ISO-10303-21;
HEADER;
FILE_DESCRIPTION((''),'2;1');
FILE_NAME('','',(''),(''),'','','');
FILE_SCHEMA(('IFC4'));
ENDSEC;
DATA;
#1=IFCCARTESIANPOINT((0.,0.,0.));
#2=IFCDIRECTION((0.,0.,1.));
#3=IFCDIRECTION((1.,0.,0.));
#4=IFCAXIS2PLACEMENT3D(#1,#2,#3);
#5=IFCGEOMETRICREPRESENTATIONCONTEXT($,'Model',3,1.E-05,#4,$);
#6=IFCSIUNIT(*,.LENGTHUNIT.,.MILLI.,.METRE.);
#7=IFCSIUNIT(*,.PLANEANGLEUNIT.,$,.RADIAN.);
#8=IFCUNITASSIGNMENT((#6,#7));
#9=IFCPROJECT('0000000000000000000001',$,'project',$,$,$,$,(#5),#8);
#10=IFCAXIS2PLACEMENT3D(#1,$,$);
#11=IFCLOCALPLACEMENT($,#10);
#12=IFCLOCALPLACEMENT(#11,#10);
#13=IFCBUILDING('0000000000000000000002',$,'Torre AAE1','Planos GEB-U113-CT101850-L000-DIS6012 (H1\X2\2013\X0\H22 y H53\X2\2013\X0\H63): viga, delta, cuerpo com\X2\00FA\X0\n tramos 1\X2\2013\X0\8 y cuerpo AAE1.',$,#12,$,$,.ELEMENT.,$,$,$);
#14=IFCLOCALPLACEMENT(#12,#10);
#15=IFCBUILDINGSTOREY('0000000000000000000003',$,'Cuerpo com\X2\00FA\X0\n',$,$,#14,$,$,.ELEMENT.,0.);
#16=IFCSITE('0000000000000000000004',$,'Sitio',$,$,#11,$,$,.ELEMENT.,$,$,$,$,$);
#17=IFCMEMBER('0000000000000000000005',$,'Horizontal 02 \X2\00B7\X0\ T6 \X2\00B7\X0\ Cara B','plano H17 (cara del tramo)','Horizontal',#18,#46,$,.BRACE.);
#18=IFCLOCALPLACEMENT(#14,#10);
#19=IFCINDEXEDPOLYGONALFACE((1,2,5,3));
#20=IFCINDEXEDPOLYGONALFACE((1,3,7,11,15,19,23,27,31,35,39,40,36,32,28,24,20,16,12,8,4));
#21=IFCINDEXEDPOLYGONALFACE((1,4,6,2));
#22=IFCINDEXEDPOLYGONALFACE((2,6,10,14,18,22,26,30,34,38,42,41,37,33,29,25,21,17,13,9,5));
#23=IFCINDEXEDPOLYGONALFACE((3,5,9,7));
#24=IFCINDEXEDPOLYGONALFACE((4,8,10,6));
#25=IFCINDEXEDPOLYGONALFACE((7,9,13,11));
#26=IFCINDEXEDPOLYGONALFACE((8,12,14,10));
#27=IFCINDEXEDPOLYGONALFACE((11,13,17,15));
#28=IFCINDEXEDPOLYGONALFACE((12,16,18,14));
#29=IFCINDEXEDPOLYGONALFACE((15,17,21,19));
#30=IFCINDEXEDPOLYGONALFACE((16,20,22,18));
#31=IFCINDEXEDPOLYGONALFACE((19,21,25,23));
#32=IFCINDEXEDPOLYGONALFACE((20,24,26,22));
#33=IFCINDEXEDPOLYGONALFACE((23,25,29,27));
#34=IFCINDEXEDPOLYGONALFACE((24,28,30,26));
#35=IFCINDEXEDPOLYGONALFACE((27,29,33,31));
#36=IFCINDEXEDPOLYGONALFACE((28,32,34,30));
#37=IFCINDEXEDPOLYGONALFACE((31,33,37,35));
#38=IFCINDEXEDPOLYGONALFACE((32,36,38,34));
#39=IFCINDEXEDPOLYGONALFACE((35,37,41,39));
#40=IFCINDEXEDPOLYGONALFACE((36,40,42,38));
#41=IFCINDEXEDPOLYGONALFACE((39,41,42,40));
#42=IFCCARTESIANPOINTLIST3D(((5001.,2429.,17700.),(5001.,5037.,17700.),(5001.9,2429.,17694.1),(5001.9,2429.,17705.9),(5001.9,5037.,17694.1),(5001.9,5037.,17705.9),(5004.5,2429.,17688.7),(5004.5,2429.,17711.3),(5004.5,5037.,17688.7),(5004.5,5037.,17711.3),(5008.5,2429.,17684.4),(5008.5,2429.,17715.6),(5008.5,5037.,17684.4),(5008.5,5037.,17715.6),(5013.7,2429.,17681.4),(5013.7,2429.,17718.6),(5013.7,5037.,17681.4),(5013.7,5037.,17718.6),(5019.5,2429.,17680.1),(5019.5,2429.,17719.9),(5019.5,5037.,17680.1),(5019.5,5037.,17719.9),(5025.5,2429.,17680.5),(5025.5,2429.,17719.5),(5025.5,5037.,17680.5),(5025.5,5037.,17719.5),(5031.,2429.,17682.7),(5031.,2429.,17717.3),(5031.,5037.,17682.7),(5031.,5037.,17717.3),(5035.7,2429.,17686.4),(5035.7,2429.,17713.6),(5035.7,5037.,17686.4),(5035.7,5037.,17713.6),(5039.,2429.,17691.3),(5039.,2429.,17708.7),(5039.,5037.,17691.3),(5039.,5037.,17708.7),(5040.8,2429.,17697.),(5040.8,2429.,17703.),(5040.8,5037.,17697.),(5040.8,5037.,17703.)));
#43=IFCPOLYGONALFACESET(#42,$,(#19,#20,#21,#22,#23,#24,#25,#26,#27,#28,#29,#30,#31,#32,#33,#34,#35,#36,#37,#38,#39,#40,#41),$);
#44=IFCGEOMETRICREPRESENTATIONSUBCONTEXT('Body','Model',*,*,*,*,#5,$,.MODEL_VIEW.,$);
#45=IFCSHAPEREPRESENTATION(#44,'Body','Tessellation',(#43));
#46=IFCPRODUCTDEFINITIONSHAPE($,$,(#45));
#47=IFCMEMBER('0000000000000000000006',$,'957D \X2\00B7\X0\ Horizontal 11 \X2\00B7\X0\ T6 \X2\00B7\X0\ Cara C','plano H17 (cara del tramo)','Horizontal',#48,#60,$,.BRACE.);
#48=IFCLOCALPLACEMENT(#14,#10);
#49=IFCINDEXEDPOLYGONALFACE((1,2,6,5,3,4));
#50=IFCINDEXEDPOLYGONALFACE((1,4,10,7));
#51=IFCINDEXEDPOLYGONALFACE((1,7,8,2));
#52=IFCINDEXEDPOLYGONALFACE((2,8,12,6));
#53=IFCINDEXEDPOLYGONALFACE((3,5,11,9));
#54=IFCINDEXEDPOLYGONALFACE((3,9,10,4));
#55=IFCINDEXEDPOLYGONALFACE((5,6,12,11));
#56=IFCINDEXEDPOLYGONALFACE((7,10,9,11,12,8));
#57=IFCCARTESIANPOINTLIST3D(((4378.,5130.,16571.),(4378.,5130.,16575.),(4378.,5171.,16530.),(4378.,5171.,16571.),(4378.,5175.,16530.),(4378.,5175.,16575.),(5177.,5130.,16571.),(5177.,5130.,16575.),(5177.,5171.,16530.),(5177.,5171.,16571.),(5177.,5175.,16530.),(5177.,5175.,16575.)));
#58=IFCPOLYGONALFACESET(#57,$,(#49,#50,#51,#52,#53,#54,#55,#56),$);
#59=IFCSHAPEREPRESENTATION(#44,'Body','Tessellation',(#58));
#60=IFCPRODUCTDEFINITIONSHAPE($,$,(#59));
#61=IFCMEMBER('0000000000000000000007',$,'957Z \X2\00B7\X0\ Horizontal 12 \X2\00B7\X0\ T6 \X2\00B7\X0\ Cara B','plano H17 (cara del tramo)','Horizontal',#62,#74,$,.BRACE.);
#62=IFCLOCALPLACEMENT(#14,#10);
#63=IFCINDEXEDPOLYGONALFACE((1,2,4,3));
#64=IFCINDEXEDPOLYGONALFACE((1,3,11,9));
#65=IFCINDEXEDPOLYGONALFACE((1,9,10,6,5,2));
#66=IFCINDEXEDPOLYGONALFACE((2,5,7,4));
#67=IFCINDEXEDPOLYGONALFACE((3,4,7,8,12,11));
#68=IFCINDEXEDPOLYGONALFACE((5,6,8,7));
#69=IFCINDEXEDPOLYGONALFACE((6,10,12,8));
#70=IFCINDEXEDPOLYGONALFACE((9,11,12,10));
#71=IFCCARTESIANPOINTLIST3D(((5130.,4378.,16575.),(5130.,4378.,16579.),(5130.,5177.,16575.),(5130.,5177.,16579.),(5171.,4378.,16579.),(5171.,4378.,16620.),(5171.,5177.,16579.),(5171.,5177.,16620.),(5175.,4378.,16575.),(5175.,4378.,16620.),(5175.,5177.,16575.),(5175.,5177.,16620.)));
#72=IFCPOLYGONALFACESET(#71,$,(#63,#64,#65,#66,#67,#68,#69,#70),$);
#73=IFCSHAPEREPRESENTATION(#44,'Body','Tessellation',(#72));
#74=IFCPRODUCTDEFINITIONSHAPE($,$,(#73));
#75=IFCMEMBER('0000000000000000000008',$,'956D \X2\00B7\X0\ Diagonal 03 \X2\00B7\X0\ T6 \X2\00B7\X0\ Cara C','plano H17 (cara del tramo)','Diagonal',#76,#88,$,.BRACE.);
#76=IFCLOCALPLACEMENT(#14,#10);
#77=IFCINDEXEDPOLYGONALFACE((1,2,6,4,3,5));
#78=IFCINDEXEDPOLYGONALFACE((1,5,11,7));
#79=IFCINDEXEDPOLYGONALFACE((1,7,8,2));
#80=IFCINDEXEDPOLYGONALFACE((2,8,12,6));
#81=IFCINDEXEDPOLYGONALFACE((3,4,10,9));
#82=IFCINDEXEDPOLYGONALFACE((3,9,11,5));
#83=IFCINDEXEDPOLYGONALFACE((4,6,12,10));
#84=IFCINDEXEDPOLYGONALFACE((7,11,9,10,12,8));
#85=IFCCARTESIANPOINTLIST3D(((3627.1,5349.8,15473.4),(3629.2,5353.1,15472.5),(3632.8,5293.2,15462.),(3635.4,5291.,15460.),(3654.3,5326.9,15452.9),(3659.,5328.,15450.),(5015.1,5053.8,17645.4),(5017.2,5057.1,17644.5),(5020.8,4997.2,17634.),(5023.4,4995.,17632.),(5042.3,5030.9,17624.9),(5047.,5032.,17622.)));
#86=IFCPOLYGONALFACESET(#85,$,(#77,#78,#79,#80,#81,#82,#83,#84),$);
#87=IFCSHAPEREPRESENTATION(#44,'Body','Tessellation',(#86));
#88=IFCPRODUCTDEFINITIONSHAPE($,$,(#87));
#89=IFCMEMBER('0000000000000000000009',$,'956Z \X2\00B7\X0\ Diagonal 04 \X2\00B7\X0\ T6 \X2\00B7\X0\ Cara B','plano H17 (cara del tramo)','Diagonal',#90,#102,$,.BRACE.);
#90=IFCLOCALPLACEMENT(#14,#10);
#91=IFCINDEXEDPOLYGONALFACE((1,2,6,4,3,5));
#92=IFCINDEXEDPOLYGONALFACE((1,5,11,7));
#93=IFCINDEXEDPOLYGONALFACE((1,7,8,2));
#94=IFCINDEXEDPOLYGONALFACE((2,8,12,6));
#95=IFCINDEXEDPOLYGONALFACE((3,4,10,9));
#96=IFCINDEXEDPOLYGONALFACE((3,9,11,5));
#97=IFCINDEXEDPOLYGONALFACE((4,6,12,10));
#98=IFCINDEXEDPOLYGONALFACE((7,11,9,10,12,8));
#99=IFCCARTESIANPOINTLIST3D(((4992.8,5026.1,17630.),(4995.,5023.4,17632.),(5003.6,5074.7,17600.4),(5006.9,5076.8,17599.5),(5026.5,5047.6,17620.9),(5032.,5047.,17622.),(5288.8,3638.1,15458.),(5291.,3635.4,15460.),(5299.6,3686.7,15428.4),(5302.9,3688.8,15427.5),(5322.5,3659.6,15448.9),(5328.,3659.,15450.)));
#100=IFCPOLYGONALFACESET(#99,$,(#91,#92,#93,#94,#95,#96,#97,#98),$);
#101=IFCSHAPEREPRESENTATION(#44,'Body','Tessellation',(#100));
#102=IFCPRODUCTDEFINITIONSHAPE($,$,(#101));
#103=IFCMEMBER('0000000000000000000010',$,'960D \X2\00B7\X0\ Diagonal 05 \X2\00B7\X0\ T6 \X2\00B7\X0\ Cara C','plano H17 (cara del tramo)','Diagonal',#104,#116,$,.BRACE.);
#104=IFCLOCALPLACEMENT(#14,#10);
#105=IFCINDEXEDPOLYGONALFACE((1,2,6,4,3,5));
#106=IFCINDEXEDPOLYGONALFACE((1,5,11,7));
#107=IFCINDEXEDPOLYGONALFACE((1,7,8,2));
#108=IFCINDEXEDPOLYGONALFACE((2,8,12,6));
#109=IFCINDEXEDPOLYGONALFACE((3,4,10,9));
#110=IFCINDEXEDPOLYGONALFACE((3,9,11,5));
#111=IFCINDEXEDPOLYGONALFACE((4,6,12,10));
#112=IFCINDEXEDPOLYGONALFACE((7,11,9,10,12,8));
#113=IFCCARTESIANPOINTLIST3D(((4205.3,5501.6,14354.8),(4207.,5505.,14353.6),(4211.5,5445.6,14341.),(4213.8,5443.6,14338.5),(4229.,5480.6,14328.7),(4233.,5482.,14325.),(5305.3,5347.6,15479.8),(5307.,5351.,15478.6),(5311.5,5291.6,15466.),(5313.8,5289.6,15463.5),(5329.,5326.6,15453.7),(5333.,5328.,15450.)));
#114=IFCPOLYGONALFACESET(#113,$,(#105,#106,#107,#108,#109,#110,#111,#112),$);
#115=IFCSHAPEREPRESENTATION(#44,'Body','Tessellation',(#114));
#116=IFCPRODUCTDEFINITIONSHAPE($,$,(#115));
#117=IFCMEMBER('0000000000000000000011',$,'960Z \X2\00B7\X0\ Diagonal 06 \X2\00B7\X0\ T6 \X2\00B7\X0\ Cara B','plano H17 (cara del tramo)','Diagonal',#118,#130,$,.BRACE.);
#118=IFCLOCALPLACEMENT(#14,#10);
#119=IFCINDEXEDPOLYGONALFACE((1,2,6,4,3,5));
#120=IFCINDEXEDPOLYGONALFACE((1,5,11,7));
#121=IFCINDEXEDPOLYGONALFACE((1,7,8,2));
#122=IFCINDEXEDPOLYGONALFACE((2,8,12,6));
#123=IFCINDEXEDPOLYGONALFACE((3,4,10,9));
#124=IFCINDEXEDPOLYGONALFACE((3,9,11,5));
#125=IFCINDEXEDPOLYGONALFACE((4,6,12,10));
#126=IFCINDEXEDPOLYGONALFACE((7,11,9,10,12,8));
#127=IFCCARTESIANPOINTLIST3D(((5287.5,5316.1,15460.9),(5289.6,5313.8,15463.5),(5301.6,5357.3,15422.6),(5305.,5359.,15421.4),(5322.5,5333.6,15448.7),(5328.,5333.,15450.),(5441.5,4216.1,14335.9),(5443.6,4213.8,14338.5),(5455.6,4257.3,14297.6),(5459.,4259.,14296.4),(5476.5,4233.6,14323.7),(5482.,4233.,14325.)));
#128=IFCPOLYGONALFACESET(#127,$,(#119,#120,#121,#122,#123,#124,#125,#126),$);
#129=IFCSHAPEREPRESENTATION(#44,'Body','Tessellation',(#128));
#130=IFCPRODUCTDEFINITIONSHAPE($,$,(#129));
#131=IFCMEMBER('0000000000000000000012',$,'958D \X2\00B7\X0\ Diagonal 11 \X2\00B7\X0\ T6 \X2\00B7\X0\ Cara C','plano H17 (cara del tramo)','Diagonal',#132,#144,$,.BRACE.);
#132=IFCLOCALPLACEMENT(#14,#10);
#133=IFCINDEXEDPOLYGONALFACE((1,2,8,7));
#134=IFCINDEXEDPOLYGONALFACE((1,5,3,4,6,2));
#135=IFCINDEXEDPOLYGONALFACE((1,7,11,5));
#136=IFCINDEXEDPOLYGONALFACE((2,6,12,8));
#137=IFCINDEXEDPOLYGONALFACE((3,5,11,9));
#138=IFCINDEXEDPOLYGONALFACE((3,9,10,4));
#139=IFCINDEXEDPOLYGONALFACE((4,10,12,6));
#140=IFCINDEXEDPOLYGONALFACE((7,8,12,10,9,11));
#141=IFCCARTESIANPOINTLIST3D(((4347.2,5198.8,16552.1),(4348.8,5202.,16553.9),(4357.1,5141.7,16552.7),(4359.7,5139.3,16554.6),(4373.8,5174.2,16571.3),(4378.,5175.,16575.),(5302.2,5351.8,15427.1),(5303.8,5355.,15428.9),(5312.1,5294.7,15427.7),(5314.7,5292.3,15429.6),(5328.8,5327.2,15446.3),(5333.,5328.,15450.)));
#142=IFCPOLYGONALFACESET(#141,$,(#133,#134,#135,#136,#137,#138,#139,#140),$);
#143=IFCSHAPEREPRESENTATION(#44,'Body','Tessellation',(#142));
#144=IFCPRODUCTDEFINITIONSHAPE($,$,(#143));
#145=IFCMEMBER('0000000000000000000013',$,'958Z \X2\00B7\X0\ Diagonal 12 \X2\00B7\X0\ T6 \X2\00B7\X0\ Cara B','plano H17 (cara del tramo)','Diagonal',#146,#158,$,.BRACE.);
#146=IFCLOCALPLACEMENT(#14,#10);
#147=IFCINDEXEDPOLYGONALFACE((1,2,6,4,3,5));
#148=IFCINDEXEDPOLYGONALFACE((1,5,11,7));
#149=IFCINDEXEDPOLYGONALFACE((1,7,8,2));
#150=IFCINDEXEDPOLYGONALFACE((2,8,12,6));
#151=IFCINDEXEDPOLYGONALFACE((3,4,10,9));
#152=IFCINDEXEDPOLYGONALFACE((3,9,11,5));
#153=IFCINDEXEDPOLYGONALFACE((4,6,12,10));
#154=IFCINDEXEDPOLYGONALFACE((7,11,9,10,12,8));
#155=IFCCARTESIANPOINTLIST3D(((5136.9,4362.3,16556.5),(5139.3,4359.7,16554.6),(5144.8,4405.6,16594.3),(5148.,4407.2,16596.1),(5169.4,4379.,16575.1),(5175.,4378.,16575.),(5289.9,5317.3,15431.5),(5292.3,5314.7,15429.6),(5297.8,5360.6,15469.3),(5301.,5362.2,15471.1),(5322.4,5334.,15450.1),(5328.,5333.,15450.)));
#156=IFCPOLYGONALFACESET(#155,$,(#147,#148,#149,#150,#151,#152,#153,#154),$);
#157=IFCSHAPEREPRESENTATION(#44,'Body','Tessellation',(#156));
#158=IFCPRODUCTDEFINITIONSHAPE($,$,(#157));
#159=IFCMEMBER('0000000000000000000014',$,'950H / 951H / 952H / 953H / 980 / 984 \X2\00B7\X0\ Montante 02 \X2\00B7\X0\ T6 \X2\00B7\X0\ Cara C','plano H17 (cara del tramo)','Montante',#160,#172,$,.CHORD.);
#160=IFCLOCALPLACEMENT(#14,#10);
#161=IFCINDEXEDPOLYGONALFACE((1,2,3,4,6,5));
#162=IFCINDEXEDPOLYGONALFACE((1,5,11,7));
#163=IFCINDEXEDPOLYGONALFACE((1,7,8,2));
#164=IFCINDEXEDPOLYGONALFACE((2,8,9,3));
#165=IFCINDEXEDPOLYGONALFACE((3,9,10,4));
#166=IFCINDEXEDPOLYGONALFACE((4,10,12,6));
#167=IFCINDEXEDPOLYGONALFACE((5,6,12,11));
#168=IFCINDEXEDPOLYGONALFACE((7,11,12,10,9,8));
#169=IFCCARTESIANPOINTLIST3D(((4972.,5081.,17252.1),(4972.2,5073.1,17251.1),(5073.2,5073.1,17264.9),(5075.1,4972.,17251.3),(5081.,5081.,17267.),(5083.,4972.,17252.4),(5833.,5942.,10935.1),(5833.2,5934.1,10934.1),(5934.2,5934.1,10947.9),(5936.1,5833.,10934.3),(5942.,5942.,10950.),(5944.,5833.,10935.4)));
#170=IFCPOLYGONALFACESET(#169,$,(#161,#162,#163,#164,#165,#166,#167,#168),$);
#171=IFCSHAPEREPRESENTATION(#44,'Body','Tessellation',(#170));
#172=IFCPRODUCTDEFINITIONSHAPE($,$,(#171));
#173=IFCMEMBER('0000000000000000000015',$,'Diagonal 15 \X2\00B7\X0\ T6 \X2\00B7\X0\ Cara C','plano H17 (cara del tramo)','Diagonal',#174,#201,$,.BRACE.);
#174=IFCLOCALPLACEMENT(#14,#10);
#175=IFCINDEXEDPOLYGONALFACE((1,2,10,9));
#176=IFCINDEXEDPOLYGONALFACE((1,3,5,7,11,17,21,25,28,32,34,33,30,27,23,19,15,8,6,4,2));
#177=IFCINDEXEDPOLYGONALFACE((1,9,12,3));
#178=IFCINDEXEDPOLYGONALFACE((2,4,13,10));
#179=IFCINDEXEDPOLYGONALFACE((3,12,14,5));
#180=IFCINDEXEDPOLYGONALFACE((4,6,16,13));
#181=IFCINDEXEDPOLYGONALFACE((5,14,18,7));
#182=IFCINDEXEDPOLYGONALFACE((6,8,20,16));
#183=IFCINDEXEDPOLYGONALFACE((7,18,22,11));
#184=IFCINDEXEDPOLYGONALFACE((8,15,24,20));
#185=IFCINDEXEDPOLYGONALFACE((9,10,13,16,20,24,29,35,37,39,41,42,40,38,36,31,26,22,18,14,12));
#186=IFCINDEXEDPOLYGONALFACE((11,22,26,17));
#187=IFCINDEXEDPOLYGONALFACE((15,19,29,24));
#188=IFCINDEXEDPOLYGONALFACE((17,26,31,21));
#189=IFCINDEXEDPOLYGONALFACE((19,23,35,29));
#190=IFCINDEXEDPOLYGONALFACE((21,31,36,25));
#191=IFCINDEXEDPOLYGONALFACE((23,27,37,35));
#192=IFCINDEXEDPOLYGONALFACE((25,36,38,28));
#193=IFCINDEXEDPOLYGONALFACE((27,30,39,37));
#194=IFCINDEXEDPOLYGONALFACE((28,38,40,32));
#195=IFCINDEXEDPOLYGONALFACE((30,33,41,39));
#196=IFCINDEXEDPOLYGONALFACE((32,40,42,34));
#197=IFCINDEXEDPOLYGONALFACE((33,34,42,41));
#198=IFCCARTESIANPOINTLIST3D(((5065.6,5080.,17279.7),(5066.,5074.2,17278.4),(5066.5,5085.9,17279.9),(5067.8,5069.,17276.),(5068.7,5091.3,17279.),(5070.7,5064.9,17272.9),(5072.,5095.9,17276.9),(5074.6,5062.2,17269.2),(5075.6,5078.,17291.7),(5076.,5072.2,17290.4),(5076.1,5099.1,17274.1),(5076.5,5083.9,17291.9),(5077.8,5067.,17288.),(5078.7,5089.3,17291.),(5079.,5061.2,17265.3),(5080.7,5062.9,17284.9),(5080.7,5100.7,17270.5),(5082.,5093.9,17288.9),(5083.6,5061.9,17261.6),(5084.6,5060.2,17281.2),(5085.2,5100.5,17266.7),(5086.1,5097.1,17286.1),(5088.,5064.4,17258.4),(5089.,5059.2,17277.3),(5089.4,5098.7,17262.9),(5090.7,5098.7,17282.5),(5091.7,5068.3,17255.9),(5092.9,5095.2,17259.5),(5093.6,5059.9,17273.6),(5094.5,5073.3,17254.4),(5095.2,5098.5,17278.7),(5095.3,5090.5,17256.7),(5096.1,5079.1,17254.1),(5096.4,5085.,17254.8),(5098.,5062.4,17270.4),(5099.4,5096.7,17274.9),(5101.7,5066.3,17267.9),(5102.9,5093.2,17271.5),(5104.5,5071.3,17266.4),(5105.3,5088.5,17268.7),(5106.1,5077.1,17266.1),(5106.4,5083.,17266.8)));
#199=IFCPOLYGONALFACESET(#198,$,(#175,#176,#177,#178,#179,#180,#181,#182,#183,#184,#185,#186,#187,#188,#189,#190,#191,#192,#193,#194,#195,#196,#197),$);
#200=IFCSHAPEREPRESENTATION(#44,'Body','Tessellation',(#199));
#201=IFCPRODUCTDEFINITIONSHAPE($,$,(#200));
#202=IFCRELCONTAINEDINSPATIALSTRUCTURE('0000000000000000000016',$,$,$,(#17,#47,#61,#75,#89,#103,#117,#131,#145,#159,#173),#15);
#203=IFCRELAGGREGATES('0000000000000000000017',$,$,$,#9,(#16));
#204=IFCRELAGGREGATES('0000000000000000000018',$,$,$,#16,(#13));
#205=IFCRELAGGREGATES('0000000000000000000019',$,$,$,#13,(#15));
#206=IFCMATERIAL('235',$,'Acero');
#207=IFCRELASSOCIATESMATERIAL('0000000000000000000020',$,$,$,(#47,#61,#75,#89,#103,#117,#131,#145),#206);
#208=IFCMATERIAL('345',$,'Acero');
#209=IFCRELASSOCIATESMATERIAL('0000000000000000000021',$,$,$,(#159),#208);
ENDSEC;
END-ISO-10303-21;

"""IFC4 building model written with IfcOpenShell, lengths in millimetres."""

from ifc_helpers import new_model, si_unit, frame, frame_2d, origin, origin_with_axes, place, context, subcontext, project, spatial, circle, l_section, extrude, material, element, save


model = new_model("IFC4")

# Units and contexts
model_context = context("Model", 3, precision=1e-05, world=origin_with_axes())
body_context = subcontext(model_context, "Body", "Model", "MODEL_VIEW")
ifc_project = project(units=[si_unit("LENGTHUNIT", "METRE", prefix="MILLI"), si_unit("PLANEANGLEUNIT", "RADIAN")], contexts=[model_context])

# Site, building, storey
site_placement = place(None, origin())
site = spatial("IfcSite", under=ifc_project, at=site_placement, Name="Sitio", CompositionType="ELEMENT")
building_placement = place(site_placement, origin())
building = spatial("IfcBuilding", under=site, at=building_placement, Name="Torre AAE1", Description="Planos GEB-U113-CT101850-L000-DIS6012 (H1–H22 y H53–H63): viga, delta, cuerpo común tramos 1–8 y cuerpo AAE1.", CompositionType="ELEMENT")
storey_placement = place(building_placement, origin())
storey = spatial("IfcBuildingStorey", under=building, at=storey_placement, Name="Cuerpo común", CompositionType="ELEMENT", Elevation=0.0)

# Members
for number, where, z_axis, x_axis, name in (
    (1, (5021.0, 5037.0, 17700.0), (0.0, -1.0, 0.0), (-1.0, 0.0, 0.0), "Horizontal 02 · T6 · Cara B"),
):
    element("IfcMember", number, at=place(storey_placement, frame(where, z_axis=z_axis, x_axis=x_axis)), inside=storey, Name=name, Description="plano H17 (cara del tramo)", ObjectType="Horizontal", PredefinedType="BRACE", context=body_context, shape_type="SweptSolid", body=[
        extrude(circle(Radius=20.0), None, (0.0, 0.0, 1.0), 2608.0),
    ])
ifc_material_1 = material(Name="235", Category="Acero")
for number, where, z_axis, x_axis, name in (
    (2, (4378.0, 5175.0, 16575.0), (1.0, 0.0, 0.0), (0.0, -1.0, 0.0), "957D · Horizontal 11 · T6 · Cara C"),
    (3, (5175.0, 4378.0, 16575.0), (0.0, 1.0, 0.0), (-1.0, 0.0, 0.0), "957Z · Horizontal 12 · T6 · Cara B"),
):
    element("IfcMember", number, at=place(storey_placement, frame(where, z_axis=z_axis, x_axis=x_axis)), inside=storey, material=ifc_material_1, Name=name, Description="plano H17 (cara del tramo)", ObjectType="Horizontal", PredefinedType="BRACE", context=body_context, shape_type="SweptSolid", body=[
        extrude(l_section(Depth=45.0, Width=45.0, Thickness=4.0, at=frame_2d((22.5, 22.5))), None, (0.0, 0.0, 1.0), 799.0),
    ])
for number, where, z_axis, x_axis, name in (
    (4, (5047.0, 5032.0, 17622.0), (-0.534965, 0.114085, -0.837136), (-0.523514, -0.822462, 0.222463), "956D · Diagonal 03 · T6 · Cara C"),
    (5, (5032.0, 5047.0, 17622.0), (0.114085, -0.534965, -0.837136), (-0.822462, -0.523514, 0.222463), "956Z · Diagonal 04 · T6 · Cara B"),
):
    element("IfcMember", number, at=place(storey_placement, frame(where, z_axis=z_axis, x_axis=x_axis)), inside=storey, material=ifc_material_1, Name=name, Description="plano H17 (cara del tramo)", ObjectType="Diagonal", PredefinedType="BRACE", context=body_context, shape_type="SweptSolid", body=[
        extrude(l_section(Depth=45.0, Width=45.0, Thickness=4.0, at=frame_2d((22.5, 22.5))), None, (0.0, 0.0, 1.0), 2594.6),
    ])
for number, where, z_axis, x_axis, name in (
    (6, (5333.0, 5328.0, 15450.0), (-0.695793, 0.097411, -0.711606), (-0.426031, -0.853622, 0.299712), "960D · Diagonal 05 · T6 · Cara C"),
    (7, (5328.0, 5333.0, 15450.0), (0.097411, -0.695793, -0.711606), (-0.853622, -0.426031, 0.299712), "960Z · Diagonal 06 · T6 · Cara B"),
):
    element("IfcMember", number, at=place(storey_placement, frame(where, z_axis=z_axis, x_axis=x_axis)), inside=storey, material=ifc_material_1, Name=name, Description="plano H17 (cara del tramo)", ObjectType="Diagonal", PredefinedType="BRACE", context=body_context, shape_type="SweptSolid", body=[
        extrude(l_section(Depth=45.0, Width=45.0, Thickness=4.0, at=frame_2d((22.5, 22.5))), None, (0.0, 0.0, 1.0), 1580.9),
    ])
for number, where, z_axis, x_axis, name in (
    (8, (4378.0, 5175.0, 16575.0), (0.643706, 0.103128, -0.758292), (-0.40631, -0.793627, -0.452845), "958D · Diagonal 11 · T6 · Cara C"),
    (9, (5175.0, 4378.0, 16575.0), (0.103128, 0.643706, -0.758292), (-0.793627, -0.40631, -0.452845), "958Z · Diagonal 12 · T6 · Cara B"),
):
    element("IfcMember", number, at=place(storey_placement, frame(where, z_axis=z_axis, x_axis=x_axis)), inside=storey, material=ifc_material_1, Name=name, Description="plano H17 (cara del tramo)", ObjectType="Diagonal", PredefinedType="BRACE", context=body_context, shape_type="SweptSolid", body=[
        extrude(l_section(Depth=45.0, Width=45.0, Thickness=4.0, at=frame_2d((22.5, 22.5))), None, (0.0, 0.0, 1.0), 1483.6),
    ])
ifc_material_2 = material(Name="345", Category="Acero")
member_1_placement = place(storey_placement, frame((5081.0, 5081.0, 17267.0), z_axis=(0.133835, 0.133835, -0.981925), x_axis=(0.018074, -0.991004, -0.132609)))
element("IfcMember", 10, at=member_1_placement, inside=storey, material=ifc_material_2, Name="950H / 951H / 952H / 953H / 980 / 984 · Montante 02 · T6 · Cara C", Description="plano H17 (cara del tramo)", ObjectType="Montante", PredefinedType="CHORD", context=body_context, shape_type="SweptSolid", body=[
    extrude(l_section(Depth=110.0, Width=110.0, Thickness=8.0, at=frame_2d((55.0, 55.0))), None, (0.0, 0.0, 1.0), 6433.3),
])
for number, where, z_axis, x_axis, name in (
    (11, (5091.0, 5079.0, 17279.0), (-0.635001, 0.127, -0.762001), (-0.513563, -0.806261, 0.293592), "Diagonal 15 · T6 · Cara C"),
):
    element("IfcMember", number, at=place(storey_placement, frame(where, z_axis=z_axis, x_axis=x_axis)), inside=storey, Name=name, Description="plano H17 (cara del tramo)", ObjectType="Diagonal", PredefinedType="BRACE", context=body_context, shape_type="SweptSolid", body=[
        extrude(circle(Radius=20.0), None, (0.0, 0.0, 1.0), 15.7),
    ])

save(model, "model.ifc")
